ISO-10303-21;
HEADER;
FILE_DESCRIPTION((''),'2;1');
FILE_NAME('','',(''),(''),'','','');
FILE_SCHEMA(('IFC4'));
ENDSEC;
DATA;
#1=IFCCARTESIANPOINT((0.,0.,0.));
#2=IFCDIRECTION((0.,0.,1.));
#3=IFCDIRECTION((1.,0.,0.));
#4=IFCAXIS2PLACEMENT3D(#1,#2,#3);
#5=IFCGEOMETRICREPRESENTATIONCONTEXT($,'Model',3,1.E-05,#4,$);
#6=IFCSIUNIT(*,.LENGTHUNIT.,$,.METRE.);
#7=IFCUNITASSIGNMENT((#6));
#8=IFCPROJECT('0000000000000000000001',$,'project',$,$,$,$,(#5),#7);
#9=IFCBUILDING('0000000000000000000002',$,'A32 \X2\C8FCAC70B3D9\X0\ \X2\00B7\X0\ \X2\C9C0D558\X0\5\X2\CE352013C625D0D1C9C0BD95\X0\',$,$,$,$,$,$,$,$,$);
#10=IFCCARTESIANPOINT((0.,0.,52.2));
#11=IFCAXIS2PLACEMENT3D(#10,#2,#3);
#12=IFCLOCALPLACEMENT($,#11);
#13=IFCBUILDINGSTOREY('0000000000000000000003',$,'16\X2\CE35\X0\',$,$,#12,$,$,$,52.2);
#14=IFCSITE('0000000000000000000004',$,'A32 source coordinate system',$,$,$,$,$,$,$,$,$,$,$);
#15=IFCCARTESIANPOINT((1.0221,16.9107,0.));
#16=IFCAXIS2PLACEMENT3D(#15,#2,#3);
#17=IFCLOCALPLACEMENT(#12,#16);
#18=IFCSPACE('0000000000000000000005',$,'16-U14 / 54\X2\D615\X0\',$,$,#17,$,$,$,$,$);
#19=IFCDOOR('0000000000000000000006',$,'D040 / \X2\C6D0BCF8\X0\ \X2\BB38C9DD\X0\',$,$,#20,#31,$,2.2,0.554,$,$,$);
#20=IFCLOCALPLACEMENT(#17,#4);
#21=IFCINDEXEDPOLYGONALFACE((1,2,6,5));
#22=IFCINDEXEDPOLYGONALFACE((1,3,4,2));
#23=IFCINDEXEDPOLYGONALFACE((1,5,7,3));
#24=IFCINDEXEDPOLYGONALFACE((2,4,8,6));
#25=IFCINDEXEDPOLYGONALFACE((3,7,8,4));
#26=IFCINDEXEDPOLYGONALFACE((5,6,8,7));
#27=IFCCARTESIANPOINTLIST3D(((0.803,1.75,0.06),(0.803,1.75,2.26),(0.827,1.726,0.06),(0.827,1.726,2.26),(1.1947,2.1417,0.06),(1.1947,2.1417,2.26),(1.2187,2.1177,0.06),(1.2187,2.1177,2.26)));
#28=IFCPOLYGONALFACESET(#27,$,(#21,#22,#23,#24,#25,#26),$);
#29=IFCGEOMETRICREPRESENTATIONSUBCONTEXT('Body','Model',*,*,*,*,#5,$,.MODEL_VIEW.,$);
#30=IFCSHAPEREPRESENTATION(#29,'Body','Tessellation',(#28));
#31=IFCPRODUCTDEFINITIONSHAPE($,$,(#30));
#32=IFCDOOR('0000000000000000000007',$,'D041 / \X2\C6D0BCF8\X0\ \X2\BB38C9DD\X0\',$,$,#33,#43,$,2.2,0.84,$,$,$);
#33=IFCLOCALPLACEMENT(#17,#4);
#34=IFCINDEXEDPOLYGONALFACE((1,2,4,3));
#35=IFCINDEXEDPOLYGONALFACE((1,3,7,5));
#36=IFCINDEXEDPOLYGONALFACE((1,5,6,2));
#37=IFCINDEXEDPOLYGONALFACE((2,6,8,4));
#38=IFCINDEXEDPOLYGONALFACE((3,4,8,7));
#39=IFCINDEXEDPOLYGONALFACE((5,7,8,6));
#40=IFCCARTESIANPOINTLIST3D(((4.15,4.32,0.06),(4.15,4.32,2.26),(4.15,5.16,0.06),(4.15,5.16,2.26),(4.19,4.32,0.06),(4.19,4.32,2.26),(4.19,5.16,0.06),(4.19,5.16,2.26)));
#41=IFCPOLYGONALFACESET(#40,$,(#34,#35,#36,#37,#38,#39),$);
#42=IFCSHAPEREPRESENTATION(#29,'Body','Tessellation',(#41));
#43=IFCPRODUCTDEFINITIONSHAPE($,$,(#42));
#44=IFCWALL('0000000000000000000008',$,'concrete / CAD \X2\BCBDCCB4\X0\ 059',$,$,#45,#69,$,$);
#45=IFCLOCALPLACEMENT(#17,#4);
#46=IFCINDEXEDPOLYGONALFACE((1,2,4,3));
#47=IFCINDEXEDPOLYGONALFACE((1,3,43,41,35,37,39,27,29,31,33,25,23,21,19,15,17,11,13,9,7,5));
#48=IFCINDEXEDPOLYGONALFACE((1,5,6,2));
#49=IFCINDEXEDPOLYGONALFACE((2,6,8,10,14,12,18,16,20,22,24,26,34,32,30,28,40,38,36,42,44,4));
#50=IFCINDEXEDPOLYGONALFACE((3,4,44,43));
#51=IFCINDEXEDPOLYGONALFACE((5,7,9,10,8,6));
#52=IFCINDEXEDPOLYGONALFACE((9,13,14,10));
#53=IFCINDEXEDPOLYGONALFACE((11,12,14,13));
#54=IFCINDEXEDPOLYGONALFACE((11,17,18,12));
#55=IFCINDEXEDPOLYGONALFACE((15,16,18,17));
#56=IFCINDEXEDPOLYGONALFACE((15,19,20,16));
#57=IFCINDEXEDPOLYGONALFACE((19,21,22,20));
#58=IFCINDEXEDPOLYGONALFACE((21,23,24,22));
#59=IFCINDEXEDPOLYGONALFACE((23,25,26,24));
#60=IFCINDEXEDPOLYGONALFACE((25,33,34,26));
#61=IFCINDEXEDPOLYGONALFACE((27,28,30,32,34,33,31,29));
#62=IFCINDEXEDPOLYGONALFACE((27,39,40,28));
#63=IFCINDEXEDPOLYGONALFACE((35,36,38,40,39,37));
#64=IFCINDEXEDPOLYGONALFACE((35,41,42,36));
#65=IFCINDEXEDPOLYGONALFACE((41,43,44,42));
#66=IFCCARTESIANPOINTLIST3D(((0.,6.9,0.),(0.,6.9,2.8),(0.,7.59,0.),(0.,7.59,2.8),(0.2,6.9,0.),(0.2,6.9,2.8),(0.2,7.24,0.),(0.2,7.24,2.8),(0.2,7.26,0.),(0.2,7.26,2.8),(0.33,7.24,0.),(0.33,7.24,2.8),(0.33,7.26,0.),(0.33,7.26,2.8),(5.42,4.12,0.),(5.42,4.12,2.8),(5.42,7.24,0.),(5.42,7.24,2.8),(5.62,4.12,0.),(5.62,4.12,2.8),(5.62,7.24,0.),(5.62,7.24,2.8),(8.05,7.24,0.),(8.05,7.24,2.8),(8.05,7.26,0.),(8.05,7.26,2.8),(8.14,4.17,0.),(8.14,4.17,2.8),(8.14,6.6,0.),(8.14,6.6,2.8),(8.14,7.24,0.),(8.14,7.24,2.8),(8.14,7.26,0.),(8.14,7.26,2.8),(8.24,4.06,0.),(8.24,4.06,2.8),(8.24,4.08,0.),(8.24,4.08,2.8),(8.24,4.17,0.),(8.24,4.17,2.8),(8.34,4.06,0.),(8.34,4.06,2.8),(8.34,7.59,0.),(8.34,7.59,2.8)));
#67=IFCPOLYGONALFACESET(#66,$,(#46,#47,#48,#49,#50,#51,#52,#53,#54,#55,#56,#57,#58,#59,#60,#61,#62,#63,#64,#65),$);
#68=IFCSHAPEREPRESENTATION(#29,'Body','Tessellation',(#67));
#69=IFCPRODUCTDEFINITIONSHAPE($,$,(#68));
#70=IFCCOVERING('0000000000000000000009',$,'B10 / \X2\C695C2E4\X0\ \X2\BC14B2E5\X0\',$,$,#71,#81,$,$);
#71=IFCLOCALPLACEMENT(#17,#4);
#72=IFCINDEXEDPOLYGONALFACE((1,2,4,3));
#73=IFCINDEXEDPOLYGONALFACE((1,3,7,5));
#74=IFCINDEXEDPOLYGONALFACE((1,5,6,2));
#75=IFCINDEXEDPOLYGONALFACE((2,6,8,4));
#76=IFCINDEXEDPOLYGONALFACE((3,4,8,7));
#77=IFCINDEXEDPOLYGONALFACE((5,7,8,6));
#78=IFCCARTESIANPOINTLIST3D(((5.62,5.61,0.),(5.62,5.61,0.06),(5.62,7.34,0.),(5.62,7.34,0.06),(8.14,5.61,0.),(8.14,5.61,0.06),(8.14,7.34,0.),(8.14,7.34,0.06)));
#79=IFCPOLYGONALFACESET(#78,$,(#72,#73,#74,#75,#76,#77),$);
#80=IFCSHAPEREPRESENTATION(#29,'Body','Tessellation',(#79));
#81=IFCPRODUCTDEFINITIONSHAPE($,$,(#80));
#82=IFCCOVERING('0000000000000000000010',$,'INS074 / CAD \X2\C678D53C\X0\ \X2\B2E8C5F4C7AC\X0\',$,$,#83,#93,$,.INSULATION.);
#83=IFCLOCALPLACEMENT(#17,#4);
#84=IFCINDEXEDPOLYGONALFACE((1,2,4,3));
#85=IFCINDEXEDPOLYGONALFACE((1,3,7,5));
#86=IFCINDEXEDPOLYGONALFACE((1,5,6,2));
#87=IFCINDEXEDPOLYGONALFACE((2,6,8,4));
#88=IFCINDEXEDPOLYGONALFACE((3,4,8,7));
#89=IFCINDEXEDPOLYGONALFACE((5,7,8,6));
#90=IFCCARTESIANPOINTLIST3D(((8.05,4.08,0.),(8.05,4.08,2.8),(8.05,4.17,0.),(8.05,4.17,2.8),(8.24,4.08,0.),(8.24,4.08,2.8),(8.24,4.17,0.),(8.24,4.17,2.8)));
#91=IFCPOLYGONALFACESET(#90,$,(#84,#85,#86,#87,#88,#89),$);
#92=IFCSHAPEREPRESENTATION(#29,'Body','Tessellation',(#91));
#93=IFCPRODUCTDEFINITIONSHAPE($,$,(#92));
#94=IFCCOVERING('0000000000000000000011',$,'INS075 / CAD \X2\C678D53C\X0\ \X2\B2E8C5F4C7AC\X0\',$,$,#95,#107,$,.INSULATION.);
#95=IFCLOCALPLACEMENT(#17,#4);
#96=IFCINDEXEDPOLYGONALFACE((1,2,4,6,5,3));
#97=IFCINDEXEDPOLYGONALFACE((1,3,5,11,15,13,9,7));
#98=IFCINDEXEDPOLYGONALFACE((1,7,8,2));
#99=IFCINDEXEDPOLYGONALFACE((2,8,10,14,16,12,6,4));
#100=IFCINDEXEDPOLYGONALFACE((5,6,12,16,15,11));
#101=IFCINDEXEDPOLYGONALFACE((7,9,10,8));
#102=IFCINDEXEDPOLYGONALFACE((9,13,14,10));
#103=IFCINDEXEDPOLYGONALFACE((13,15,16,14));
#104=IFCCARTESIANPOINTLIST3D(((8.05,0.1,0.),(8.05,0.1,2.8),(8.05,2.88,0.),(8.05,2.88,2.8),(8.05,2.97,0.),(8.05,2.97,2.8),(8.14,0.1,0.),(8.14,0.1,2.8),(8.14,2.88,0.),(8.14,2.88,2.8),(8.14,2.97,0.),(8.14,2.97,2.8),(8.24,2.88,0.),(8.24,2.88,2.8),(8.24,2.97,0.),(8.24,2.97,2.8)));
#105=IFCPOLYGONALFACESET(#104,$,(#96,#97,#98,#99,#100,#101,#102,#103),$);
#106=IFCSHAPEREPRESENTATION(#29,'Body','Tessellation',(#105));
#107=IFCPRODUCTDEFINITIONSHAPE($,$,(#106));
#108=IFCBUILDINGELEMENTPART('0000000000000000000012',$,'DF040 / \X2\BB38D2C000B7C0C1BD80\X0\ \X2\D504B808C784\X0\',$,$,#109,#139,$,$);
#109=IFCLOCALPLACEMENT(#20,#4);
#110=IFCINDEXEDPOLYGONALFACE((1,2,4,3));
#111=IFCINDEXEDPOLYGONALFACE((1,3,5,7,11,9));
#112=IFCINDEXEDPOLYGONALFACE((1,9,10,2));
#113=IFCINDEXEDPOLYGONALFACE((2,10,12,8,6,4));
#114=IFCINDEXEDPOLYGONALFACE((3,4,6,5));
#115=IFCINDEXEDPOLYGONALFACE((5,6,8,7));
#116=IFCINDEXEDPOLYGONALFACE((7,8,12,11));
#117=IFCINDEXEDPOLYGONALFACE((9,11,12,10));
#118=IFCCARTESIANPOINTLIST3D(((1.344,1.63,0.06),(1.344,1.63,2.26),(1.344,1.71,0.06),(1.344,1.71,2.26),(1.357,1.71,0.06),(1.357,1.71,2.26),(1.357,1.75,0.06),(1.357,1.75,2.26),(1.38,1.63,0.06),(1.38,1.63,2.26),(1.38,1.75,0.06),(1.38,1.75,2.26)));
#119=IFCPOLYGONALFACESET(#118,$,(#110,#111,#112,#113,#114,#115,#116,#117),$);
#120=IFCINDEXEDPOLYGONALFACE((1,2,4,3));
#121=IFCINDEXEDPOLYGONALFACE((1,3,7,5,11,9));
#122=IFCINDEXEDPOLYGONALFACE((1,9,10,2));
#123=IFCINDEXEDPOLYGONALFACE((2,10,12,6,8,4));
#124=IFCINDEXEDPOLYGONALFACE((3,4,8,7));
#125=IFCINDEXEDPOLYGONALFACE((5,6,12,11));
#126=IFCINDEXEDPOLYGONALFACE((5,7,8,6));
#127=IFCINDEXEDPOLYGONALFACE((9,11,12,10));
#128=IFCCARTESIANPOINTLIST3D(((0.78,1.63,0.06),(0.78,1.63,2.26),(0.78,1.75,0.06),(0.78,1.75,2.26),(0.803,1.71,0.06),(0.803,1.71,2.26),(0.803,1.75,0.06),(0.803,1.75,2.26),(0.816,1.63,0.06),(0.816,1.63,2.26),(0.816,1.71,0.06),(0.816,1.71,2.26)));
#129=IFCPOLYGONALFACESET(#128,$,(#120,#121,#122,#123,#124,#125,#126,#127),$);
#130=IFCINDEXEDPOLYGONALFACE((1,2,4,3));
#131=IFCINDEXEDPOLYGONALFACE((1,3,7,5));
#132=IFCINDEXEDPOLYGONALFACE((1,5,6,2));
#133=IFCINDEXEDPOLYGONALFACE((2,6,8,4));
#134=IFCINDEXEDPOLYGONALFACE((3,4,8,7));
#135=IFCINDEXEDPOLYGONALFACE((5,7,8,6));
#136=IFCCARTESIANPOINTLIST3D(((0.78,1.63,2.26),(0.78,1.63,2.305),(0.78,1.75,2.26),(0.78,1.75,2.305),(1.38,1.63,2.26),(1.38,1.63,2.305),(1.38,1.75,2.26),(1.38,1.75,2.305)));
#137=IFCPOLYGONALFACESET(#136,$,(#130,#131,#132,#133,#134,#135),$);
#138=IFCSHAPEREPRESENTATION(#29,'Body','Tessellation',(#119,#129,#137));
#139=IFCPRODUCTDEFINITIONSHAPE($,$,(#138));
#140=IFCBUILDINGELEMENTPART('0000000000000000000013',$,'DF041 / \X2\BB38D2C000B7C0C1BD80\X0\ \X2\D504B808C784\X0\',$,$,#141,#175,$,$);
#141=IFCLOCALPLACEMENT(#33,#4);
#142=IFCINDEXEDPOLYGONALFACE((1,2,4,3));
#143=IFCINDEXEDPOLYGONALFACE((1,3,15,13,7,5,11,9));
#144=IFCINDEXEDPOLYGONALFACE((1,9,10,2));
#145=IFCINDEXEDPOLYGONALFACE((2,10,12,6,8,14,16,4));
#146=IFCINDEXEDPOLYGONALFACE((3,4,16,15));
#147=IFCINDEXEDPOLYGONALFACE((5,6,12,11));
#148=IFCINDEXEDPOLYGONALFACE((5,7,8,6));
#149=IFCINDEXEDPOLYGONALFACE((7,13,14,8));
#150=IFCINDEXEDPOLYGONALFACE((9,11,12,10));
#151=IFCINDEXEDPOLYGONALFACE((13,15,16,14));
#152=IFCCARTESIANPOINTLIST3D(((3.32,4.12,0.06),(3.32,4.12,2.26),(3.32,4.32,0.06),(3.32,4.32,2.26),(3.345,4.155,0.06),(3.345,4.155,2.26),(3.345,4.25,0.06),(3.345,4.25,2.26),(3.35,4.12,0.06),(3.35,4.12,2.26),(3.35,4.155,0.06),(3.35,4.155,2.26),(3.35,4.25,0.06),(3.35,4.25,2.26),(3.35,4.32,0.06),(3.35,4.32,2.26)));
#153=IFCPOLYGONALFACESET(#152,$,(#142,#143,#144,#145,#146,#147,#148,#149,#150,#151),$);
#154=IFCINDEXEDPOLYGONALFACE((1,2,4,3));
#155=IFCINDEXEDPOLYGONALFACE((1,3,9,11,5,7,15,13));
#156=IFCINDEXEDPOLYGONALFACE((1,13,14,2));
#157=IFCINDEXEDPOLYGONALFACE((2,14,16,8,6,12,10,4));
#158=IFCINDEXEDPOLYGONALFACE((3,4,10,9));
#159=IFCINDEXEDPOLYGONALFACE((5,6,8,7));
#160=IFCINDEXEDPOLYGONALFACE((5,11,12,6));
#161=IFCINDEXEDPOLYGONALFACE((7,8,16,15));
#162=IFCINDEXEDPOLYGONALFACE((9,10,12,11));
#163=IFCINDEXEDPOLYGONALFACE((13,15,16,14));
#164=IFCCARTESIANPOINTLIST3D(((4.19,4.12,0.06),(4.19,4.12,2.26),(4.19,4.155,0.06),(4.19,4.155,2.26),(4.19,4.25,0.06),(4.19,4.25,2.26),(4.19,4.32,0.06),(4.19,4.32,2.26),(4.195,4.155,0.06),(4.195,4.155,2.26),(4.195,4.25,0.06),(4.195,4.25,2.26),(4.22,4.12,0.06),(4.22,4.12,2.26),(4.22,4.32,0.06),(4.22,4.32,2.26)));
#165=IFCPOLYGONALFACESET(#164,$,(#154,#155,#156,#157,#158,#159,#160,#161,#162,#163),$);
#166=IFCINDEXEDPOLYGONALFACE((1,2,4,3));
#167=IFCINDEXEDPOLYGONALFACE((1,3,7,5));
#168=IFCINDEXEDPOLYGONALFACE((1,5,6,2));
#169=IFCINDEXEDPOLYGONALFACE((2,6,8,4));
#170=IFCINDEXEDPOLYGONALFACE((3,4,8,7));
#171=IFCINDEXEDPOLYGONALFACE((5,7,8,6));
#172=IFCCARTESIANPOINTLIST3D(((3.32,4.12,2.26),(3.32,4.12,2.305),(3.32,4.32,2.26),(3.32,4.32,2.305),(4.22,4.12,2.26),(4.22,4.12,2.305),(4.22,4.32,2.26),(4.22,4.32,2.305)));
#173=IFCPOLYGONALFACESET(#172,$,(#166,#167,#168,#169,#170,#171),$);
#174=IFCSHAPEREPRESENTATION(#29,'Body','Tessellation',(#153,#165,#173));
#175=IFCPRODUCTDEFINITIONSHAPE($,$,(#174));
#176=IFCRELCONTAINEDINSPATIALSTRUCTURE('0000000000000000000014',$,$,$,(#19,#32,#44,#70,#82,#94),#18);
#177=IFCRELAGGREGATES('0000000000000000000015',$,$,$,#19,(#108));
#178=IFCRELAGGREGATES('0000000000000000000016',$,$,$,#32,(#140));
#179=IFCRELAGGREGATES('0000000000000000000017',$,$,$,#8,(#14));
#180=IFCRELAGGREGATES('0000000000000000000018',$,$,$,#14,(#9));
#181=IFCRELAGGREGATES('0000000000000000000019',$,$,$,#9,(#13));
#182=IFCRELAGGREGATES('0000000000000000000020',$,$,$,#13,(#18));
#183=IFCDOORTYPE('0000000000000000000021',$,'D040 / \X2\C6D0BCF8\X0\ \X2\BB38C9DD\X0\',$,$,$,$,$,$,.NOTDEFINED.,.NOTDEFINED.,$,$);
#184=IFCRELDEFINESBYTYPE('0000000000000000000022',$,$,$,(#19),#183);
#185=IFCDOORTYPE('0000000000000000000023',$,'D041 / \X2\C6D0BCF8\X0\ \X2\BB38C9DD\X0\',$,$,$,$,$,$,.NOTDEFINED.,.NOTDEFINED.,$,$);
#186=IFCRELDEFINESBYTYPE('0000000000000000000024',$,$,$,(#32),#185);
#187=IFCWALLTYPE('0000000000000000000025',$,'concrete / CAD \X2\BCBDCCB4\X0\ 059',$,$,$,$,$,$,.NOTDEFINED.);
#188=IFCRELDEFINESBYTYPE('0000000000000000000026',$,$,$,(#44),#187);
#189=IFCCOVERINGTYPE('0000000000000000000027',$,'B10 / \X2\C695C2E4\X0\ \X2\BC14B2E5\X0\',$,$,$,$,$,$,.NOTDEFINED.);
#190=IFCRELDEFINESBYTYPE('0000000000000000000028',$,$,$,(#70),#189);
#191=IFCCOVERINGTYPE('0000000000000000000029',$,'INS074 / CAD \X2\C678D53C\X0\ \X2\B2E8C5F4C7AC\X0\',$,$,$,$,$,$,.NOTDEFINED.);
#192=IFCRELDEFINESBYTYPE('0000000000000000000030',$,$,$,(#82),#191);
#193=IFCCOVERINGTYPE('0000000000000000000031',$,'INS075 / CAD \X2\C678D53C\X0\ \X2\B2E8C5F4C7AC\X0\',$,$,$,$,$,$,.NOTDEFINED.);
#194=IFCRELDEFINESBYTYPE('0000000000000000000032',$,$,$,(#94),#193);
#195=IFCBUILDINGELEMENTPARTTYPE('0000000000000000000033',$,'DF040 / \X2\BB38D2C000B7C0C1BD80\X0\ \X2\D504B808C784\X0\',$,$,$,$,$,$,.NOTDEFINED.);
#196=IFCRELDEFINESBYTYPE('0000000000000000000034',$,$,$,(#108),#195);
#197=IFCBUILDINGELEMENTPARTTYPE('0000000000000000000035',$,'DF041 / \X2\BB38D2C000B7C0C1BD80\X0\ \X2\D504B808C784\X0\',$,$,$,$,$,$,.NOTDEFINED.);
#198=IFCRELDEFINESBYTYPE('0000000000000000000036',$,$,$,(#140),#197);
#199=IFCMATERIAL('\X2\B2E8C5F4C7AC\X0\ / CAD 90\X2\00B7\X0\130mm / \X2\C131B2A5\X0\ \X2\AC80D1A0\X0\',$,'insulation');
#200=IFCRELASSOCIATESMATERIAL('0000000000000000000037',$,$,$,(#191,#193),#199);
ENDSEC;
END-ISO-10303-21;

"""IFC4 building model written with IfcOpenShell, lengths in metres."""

from ifc_helpers import new_model, si_unit, frame, origin, origin_with_axes, place, context, subcontext, project, spatial, polyline, outline, extrude, source, transform, mapped, material, type_object, type_shapes, element, aggregate, save


model = new_model("IFC4")

# Units and contexts
model_context = context("Model", 3, precision=1e-05, world=origin_with_axes())
body_context = subcontext(model_context, "Body", "Model", "MODEL_VIEW")
ifc_project = project(units=[si_unit("LENGTHUNIT", "METRE")], contexts=[model_context])

# Site, building, storey, space
storey_placement = place(None, frame((0.0, 0.0, 52.2), z_axis=(0.0, 0.0, 1.0), x_axis=(1.0, 0.0, 0.0)))
space_1_placement = place(storey_placement, frame((1.0221, 16.9107, 0.0), z_axis=(0.0, 0.0, 1.0), x_axis=(1.0, 0.0, 0.0)))
site = spatial("IfcSite", under=ifc_project, Name="A32 source coordinate system")
building = spatial("IfcBuilding", under=site, Name="A32 주거동 · 지하5층–옥탑지붕")
storey = spatial("IfcBuildingStorey", under=building, at=storey_placement, Name="16층", Elevation=52.2)
space_1 = spatial("IfcSpace", under=storey, at=space_1_placement, Name="16-U14 / 54형")

# Doors
door_type_1 = type_object("IfcDoorType", Name="D040 / 원본 문짝", OperationType="NOTDEFINED", PredefinedType="NOTDEFINED")
shared_shape_1 = source(origin(), body_context, "Body", "SweptSolid", [
    extrude(outline(polyline([(0.803, 1.75), (1.1947, 2.1417), (1.2187, 2.1177), (0.827, 1.726), (0.803, 1.75)])), frame((0.0, 0.0, 0.06)), (0.0, 0.0, 1.0), 2.2),
])
type_shapes(door_type_1, [shared_shape_1])
door_1_placement = place(space_1_placement, origin_with_axes())
door_1 = element("IfcDoor", 1, at=door_1_placement, inside=space_1, type_object=door_type_1, Name="D040 / 원본 문짝", OverallHeight=2.2, OverallWidth=0.554, context=body_context, shape_type="MappedRepresentation", body=[
    mapped(shared_shape_1, transform((0.0, 0.0, 0.0), scale=1.0)),
])
door_type_2 = type_object("IfcDoorType", Name="D041 / 원본 문짝", OperationType="NOTDEFINED", PredefinedType="NOTDEFINED")
shared_shape_2 = source(origin(), body_context, "Body", "SweptSolid", [
    extrude(outline(polyline([(4.15, 5.16), (4.19, 5.16), (4.19, 4.32), (4.15, 4.32), (4.15, 5.16)])), frame((0.0, 0.0, 0.06)), (0.0, 0.0, 1.0), 2.2),
])
type_shapes(door_type_2, [shared_shape_2])
door_2_placement = place(space_1_placement, origin_with_axes())
door_2 = element("IfcDoor", 2, at=door_2_placement, inside=space_1, type_object=door_type_2, Name="D041 / 원본 문짝", OverallHeight=2.2, OverallWidth=0.84, context=body_context, shape_type="MappedRepresentation", body=[
    mapped(shared_shape_2, transform((0.0, 0.0, 0.0), scale=1.0)),
])

# Wall
wall_type_1 = type_object("IfcWallType", Name="concrete / CAD 벽체 059", PredefinedType="NOTDEFINED")
shared_shape_3 = source(origin(), body_context, "Body", "SweptSolid", [
    extrude(outline(polyline([(8.05, 7.26), (8.05, 7.24), (5.62, 7.24), (5.62, 4.12), (5.42, 4.12), (5.42, 7.24), (0.33, 7.24), (0.33, 7.26), (0.2, 7.26), (0.2, 7.24), (0.2, 6.9), (0.0, 6.9), (0.0, 7.59), (8.34, 7.59), (8.34, 4.06), (8.24, 4.06), (8.24, 4.08), (8.24, 4.17), (8.14, 4.17), (8.14, 6.6), (8.14, 7.24), (8.14, 7.26), (8.05, 7.26)])), origin(), (0.0, 0.0, 1.0), 2.8),
])
type_shapes(wall_type_1, [shared_shape_3])
wall_1_placement = place(space_1_placement, origin_with_axes())
element("IfcWall", 3, at=wall_1_placement, inside=space_1, type_object=wall_type_1, Name="concrete / CAD 벽체 059", context=body_context, shape_type="MappedRepresentation", body=[
    mapped(shared_shape_3, transform((0.0, 0.0, 0.0), scale=1.0)),
])

# Coverings
covering_type_1 = type_object("IfcCoveringType", Name="B10 / 욕실 바닥", PredefinedType="NOTDEFINED")
shared_shape_4 = source(origin(), body_context, "Body", "SweptSolid", [
    extrude(outline(polyline([(8.14, 5.61), (5.62, 5.61), (5.62, 7.34), (8.14, 7.34), (8.14, 5.61)])), origin(), (0.0, 0.0, 1.0), 0.06),
])
type_shapes(covering_type_1, [shared_shape_4])
covering_1_placement = place(space_1_placement, origin_with_axes())
element("IfcCovering", 4, at=covering_1_placement, inside=space_1, type_object=covering_type_1, Name="B10 / 욕실 바닥", context=body_context, shape_type="MappedRepresentation", body=[
    mapped(shared_shape_4, transform((0.0, 0.0, 0.0), scale=1.0)),
])
ifc_material = material(Name="단열재 / CAD 90·130mm / 성능 검토", Category="insulation")
covering_type_2 = type_object("IfcCoveringType", Name="INS074 / CAD 외피 단열재", PredefinedType="NOTDEFINED", material=ifc_material)
shared_shape_5 = source(origin(), body_context, "Body", "SweptSolid", [
    extrude(outline(polyline([(8.05, 4.08), (8.05, 4.17), (8.24, 4.17), (8.24, 4.08), (8.05, 4.08)])), origin(), (0.0, 0.0, 1.0), 2.8),
])
type_shapes(covering_type_2, [shared_shape_5])
covering_2_placement = place(space_1_placement, origin_with_axes())
element("IfcCovering", 5, at=covering_2_placement, inside=space_1, type_object=covering_type_2, Name="INS074 / CAD 외피 단열재", PredefinedType="INSULATION", context=body_context, shape_type="MappedRepresentation", body=[
    mapped(shared_shape_5, transform((0.0, 0.0, 0.0), scale=1.0)),
])
covering_type_3 = type_object("IfcCoveringType", Name="INS075 / CAD 외피 단열재", PredefinedType="NOTDEFINED", material=ifc_material)
shared_shape_6 = source(origin(), body_context, "Body", "SweptSolid", [
    extrude(outline(polyline([(8.24, 2.88), (8.14, 2.88), (8.14, 0.1), (8.05, 0.1), (8.05, 2.88), (8.05, 2.97), (8.14, 2.97), (8.24, 2.97), (8.24, 2.88)])), origin(), (0.0, 0.0, 1.0), 2.8),
])
type_shapes(covering_type_3, [shared_shape_6])
covering_3_placement = place(space_1_placement, origin_with_axes())
element("IfcCovering", 6, at=covering_3_placement, inside=space_1, type_object=covering_type_3, Name="INS075 / CAD 외피 단열재", PredefinedType="INSULATION", context=body_context, shape_type="MappedRepresentation", body=[
    mapped(shared_shape_6, transform((0.0, 0.0, 0.0), scale=1.0)),
])

# Building element parts
building_element_part_type_1 = type_object("IfcBuildingElementPartType", Name="DF040 / 문틀·상부 프레임", PredefinedType="NOTDEFINED")
shared_shape_7 = source(origin(), body_context, "Body", "SweptSolid", [
    extrude(outline(polyline([(1.344, 1.63), (1.344, 1.71), (1.357, 1.71), (1.357, 1.75), (1.38, 1.75), (1.38, 1.63), (1.344, 1.63)])), frame((0.0, 0.0, 0.06)), (0.0, 0.0, 1.0), 2.2),
    extrude(outline(polyline([(0.78, 1.75), (0.803, 1.75), (0.803, 1.71), (0.816, 1.71), (0.816, 1.63), (0.78, 1.63), (0.78, 1.75)])), frame((0.0, 0.0, 0.06)), (0.0, 0.0, 1.0), 2.2),
    extrude(outline(polyline([(0.78, 1.63), (0.78, 1.75), (1.38, 1.75), (1.38, 1.63), (0.78, 1.63)])), frame((0.0, 0.0, 2.26)), (0.0, 0.0, 1.0), 0.045),
])
type_shapes(building_element_part_type_1, [shared_shape_7])
building_element_part_1_placement = place(door_1_placement, origin_with_axes())
building_element_part_1 = element("IfcBuildingElementPart", 7, at=building_element_part_1_placement, type_object=building_element_part_type_1, Name="DF040 / 문틀·상부 프레임", context=body_context, shape_type="MappedRepresentation", body=[
    mapped(shared_shape_7, transform((0.0, 0.0, 0.0), scale=1.0)),
])
aggregate(door_1, [building_element_part_1])
building_element_part_type_2 = type_object("IfcBuildingElementPartType", Name="DF041 / 문틀·상부 프레임", PredefinedType="NOTDEFINED")
shared_shape_8 = source(origin(), body_context, "Body", "SweptSolid", [
    extrude(outline(polyline([(3.35, 4.32), (3.35, 4.25), (3.345, 4.25), (3.345, 4.155), (3.35, 4.155), (3.35, 4.12), (3.32, 4.12), (3.32, 4.32), (3.35, 4.32)])), frame((0.0, 0.0, 0.06)), (0.0, 0.0, 1.0), 2.2),
    extrude(outline(polyline([(4.22, 4.12), (4.19, 4.12), (4.19, 4.155), (4.195, 4.155), (4.195, 4.25), (4.19, 4.25), (4.19, 4.32), (4.22, 4.32), (4.22, 4.12)])), frame((0.0, 0.0, 0.06)), (0.0, 0.0, 1.0), 2.2),
    extrude(outline(polyline([(3.32, 4.12), (3.32, 4.32), (4.22, 4.32), (4.22, 4.12), (3.32, 4.12)])), frame((0.0, 0.0, 2.26)), (0.0, 0.0, 1.0), 0.045),
])
type_shapes(building_element_part_type_2, [shared_shape_8])
building_element_part_2_placement = place(door_2_placement, origin_with_axes())
building_element_part_2 = element("IfcBuildingElementPart", 8, at=building_element_part_2_placement, type_object=building_element_part_type_2, Name="DF041 / 문틀·상부 프레임", context=body_context, shape_type="MappedRepresentation", body=[
    mapped(shared_shape_8, transform((0.0, 0.0, 0.0), scale=1.0)),
])
aggregate(door_2, [building_element_part_2])

save(model, "model.ifc")
